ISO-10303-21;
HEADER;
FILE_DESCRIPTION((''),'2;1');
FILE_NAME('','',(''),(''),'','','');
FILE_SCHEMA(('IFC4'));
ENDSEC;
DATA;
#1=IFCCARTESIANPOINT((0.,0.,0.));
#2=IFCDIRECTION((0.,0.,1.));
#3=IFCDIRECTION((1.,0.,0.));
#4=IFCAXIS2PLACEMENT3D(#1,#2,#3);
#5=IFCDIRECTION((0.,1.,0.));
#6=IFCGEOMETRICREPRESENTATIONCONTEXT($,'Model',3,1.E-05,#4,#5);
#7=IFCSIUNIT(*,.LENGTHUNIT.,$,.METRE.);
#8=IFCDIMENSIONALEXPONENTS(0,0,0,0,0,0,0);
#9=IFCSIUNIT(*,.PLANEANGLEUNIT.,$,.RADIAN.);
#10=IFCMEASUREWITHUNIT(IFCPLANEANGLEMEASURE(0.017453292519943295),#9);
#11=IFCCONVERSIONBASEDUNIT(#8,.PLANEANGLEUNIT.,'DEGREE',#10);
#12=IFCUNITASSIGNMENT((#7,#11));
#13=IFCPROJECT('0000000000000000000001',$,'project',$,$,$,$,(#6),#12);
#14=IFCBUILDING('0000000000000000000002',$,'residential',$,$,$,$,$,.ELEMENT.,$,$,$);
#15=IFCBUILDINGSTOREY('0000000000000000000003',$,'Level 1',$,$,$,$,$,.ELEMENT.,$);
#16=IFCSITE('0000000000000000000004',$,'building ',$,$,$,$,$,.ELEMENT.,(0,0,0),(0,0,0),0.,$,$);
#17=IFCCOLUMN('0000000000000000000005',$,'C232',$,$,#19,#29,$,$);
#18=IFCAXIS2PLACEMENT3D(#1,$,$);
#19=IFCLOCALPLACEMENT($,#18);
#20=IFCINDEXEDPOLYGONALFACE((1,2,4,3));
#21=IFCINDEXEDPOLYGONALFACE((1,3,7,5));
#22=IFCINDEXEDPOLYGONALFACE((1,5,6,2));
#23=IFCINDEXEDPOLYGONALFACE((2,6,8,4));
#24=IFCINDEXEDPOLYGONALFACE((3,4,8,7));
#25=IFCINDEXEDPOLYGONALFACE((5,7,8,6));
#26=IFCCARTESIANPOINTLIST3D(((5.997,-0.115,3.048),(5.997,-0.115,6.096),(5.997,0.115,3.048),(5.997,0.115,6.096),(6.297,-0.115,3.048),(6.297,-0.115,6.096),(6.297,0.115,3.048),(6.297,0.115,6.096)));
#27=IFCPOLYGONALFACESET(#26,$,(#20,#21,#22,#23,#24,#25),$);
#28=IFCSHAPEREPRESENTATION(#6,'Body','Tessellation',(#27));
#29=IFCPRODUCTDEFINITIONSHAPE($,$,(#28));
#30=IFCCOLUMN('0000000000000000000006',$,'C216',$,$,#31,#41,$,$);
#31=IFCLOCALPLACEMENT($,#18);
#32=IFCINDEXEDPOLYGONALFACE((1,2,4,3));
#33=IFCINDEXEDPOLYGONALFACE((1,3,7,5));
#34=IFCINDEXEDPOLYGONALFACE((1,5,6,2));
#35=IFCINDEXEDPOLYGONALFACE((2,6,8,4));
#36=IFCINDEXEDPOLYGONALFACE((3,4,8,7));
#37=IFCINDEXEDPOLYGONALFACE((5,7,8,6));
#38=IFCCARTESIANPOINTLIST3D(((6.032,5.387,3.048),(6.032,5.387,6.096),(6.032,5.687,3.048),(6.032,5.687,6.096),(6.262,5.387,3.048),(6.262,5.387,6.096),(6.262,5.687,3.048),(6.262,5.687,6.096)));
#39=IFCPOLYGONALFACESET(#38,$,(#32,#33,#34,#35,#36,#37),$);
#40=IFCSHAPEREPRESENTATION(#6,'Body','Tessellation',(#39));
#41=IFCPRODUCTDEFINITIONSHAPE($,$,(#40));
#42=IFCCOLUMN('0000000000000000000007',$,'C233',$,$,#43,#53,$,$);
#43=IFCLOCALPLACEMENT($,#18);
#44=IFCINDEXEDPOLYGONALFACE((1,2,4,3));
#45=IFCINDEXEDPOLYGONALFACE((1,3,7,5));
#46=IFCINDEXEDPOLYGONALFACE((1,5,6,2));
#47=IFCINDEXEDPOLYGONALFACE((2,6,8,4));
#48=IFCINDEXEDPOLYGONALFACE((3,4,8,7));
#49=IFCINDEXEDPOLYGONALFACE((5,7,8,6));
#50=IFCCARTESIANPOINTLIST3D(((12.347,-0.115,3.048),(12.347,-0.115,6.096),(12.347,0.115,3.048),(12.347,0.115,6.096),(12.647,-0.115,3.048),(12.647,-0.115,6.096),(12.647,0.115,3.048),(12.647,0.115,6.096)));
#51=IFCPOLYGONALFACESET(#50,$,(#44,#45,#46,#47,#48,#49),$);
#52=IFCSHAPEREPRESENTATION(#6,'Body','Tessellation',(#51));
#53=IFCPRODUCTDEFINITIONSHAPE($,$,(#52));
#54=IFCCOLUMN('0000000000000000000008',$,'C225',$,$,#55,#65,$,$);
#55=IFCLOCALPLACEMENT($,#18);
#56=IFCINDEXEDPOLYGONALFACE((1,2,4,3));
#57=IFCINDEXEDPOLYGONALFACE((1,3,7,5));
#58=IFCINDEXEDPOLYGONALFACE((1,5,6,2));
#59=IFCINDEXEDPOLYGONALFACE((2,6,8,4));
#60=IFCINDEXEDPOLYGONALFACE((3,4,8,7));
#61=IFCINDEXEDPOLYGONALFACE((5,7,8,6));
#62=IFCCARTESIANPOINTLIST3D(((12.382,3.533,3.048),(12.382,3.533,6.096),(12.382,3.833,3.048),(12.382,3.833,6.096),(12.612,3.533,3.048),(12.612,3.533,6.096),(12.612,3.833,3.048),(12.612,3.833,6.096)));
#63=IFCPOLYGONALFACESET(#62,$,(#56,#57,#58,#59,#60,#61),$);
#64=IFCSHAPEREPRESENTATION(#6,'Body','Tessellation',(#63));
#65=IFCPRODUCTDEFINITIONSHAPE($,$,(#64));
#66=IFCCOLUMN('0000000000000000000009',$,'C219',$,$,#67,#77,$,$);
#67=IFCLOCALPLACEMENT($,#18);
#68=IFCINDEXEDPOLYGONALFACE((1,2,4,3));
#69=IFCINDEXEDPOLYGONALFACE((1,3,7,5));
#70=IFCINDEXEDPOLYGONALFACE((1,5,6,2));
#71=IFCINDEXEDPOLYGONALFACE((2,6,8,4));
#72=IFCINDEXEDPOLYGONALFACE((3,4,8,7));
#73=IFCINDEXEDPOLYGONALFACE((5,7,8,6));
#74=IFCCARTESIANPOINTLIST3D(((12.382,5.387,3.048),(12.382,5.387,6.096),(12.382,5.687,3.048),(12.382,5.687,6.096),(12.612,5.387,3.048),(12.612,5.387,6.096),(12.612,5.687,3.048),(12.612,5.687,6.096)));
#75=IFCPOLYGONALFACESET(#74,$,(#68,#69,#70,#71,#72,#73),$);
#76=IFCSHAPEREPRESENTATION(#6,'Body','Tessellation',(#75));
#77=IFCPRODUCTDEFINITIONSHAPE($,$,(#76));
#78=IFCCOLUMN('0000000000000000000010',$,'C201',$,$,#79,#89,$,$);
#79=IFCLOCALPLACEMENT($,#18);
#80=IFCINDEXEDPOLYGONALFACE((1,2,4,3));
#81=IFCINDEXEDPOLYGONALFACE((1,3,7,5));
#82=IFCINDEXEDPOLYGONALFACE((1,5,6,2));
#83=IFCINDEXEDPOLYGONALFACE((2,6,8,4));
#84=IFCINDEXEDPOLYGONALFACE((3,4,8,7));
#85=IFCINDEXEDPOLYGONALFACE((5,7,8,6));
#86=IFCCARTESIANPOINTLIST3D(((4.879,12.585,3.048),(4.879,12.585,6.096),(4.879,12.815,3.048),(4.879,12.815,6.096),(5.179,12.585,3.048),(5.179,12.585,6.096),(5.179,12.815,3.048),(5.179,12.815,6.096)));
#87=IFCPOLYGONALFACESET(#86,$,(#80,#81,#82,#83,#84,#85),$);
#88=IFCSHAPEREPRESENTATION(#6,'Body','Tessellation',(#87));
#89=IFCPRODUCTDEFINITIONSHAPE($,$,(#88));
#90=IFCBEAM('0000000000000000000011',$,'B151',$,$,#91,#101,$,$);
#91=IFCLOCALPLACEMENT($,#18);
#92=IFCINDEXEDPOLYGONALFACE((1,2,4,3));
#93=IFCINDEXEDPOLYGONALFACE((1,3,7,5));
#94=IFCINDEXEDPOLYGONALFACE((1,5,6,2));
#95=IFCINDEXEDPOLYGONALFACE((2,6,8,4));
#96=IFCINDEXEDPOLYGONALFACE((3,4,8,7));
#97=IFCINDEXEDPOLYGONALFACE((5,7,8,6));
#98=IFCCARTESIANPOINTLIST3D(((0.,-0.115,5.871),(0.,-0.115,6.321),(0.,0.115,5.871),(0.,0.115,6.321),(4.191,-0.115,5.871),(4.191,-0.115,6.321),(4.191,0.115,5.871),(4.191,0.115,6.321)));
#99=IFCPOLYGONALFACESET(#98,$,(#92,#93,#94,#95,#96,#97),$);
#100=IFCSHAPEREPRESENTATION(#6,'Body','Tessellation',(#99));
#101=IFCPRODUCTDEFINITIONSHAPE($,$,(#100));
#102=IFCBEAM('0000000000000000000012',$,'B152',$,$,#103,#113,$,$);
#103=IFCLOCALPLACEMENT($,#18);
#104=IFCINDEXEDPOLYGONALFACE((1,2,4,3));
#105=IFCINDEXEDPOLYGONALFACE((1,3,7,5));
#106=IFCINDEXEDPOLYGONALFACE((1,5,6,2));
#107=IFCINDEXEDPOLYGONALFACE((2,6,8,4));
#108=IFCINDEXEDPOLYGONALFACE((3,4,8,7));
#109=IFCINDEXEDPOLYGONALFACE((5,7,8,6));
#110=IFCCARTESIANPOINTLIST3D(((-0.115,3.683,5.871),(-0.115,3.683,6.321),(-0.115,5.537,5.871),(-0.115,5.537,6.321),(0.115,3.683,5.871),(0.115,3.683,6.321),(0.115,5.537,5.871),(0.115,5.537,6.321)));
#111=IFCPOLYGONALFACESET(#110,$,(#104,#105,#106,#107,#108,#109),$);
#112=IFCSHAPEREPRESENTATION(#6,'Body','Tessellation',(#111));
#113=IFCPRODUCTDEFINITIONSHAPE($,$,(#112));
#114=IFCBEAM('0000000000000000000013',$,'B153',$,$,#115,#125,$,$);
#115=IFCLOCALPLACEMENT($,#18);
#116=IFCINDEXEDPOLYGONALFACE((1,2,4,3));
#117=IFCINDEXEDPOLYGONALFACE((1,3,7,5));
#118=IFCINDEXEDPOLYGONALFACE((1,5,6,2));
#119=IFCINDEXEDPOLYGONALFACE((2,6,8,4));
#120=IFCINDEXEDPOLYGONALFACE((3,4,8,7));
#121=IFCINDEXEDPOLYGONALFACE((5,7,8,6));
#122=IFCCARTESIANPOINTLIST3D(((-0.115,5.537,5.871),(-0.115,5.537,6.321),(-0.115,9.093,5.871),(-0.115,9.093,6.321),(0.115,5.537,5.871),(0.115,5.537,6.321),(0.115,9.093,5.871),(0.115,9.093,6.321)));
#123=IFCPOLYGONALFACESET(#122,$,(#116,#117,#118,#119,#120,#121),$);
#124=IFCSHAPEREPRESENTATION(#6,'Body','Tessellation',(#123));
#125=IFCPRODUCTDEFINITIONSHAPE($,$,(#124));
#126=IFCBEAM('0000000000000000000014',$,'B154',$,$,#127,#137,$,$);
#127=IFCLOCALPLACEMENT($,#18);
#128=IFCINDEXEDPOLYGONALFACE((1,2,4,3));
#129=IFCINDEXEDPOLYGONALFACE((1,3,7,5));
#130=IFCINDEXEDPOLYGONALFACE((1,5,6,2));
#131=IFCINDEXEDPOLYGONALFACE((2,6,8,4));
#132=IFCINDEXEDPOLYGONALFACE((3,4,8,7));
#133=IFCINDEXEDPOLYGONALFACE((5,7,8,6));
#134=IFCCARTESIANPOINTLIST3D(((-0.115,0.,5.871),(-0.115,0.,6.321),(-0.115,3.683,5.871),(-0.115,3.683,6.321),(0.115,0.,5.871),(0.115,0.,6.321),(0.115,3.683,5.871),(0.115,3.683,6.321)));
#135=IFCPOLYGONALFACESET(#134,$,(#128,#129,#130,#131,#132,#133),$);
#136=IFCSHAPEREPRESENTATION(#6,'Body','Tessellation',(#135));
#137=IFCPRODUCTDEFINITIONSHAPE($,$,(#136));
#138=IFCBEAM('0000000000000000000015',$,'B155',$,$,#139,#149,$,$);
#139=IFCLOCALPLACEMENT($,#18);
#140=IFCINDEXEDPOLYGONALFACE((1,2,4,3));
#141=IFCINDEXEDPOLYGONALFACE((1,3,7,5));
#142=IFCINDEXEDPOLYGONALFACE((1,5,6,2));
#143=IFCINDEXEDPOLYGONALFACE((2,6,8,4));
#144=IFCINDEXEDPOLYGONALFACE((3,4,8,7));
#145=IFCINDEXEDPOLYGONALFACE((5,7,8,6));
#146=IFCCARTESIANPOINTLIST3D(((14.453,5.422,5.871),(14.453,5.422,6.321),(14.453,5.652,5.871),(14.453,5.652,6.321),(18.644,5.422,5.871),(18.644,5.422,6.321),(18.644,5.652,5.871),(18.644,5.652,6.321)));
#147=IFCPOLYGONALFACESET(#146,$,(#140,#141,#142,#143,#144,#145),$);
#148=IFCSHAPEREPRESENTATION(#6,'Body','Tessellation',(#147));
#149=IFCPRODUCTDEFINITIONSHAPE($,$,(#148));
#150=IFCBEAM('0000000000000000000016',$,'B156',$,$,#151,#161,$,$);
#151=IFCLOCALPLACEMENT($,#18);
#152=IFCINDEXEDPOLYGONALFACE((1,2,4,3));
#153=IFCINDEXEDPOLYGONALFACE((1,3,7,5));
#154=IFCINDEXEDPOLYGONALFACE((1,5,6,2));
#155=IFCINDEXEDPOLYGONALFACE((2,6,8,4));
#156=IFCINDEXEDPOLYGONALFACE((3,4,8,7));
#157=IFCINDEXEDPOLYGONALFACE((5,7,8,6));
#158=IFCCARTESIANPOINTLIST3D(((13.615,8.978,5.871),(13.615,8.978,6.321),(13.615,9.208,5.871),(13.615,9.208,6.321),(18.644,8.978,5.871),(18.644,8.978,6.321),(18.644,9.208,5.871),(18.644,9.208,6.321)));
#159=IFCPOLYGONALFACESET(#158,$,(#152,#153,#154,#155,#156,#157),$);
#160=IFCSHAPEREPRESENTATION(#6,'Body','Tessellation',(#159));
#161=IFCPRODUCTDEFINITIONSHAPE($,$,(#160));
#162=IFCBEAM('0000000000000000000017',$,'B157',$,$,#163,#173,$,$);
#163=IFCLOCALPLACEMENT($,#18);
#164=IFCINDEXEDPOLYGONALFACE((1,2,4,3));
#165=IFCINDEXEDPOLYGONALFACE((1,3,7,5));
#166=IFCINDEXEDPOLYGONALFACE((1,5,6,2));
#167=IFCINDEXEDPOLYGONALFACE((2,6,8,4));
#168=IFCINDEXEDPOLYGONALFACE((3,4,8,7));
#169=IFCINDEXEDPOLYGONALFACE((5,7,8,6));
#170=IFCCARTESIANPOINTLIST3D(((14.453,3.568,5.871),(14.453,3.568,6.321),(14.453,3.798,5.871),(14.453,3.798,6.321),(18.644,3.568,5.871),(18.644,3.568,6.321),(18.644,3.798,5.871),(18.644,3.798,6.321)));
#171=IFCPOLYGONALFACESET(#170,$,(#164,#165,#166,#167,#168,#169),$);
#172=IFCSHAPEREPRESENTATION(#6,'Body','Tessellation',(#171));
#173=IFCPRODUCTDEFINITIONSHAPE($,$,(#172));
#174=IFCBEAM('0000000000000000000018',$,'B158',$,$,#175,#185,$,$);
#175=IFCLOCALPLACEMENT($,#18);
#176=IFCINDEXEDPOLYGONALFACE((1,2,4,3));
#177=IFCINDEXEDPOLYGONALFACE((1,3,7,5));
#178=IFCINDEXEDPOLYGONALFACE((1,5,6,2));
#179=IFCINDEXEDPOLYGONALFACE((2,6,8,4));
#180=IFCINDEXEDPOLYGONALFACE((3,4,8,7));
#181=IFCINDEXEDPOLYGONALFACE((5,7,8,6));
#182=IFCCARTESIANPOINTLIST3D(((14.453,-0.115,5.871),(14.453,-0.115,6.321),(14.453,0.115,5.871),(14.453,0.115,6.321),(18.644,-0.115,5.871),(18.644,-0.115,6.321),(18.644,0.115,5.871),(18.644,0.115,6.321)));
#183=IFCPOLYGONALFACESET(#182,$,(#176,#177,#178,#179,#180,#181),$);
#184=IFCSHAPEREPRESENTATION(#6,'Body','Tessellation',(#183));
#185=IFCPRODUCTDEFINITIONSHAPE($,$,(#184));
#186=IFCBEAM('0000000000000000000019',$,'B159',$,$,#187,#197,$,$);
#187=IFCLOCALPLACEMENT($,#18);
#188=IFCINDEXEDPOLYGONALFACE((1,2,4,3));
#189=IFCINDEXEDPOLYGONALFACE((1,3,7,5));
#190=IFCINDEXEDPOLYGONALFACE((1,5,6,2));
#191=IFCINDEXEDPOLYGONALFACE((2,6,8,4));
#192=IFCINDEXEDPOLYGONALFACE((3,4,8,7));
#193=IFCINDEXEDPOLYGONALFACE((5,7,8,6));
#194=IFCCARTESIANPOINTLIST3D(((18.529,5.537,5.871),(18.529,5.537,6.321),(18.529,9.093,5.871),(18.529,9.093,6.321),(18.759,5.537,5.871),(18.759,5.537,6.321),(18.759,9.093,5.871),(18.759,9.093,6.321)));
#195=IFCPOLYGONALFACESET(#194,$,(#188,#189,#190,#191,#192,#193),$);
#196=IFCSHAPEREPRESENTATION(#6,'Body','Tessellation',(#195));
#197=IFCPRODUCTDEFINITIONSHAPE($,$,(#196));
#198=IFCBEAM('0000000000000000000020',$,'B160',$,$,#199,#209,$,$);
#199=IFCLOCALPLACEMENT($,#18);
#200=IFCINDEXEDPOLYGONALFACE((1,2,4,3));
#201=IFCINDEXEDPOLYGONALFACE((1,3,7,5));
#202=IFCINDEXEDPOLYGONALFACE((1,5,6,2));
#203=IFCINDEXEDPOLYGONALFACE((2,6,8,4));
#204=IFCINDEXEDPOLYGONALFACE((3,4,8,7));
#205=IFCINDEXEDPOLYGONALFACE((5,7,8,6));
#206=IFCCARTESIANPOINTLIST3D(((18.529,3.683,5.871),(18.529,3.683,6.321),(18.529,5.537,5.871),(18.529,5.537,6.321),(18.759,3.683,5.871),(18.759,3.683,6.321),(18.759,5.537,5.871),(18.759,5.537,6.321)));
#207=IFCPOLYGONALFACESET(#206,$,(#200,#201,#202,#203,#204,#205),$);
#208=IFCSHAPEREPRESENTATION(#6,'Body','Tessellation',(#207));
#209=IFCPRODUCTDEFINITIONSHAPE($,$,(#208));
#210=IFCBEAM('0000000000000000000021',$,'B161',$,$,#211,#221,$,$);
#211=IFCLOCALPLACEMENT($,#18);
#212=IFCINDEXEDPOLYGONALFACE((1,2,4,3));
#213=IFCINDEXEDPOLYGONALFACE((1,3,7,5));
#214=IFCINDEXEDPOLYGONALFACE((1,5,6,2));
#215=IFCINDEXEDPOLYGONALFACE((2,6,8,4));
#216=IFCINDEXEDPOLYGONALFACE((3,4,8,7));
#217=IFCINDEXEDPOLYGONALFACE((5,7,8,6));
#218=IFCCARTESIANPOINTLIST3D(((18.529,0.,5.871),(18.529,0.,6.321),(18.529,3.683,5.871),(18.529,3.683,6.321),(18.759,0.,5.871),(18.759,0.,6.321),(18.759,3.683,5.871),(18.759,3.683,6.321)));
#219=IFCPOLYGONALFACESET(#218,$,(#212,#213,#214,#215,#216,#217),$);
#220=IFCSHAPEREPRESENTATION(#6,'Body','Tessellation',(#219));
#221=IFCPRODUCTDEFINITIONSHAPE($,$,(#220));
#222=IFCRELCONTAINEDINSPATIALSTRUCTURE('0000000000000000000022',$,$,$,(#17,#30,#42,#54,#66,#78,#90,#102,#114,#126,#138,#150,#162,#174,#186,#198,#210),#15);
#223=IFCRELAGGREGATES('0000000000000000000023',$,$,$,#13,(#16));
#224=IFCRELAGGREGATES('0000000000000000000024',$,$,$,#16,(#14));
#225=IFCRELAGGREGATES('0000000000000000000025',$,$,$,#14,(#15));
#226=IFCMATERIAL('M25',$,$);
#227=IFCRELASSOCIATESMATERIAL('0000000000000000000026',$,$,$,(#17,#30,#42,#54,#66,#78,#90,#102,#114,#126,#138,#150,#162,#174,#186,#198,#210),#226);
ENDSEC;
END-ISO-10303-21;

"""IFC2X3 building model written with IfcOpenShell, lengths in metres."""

from ifc_helpers import new_model, entity, si_unit, converted_unit, direction, frame, frame_2d, origin_with_axes, place, context, project, spatial, rectangle, extrude, material, element, save


model = new_model("IFC2X3")

# Units and contexts
model_context = context("Model", 3, precision=1e-05, world=origin_with_axes(), true_north=direction((0.0, 1.0, 0.0)))
ifc_project = project(units=[si_unit("LENGTHUNIT", "METRE"), converted_unit("PLANEANGLEUNIT", "DEGREE", entity("IfcPlaneAngleMeasure", 0.017453292519943295), si_unit("PLANEANGLEUNIT", "RADIAN"), dimensions=[0, 0, 0, 0, 0, 0, 0])], contexts=[model_context])

# Site, building, storey
site = spatial("IfcSite", under=ifc_project, Name="building ", CompositionType="ELEMENT", RefLatitude=(0, 0, 0), RefLongitude=(0, 0, 0), RefElevation=0.0)
building = spatial("IfcBuilding", under=site, Name="residential", CompositionType="ELEMENT")
storey = spatial("IfcBuildingStorey", under=building, Name="Level 1", CompositionType="ELEMENT")

# Columns
ifc_material = material(Name="M25")
placement = place(None, origin_with_axes())
element("IfcColumn", 1, at=placement, inside=storey, material=ifc_material, Name="C232", context=model_context, shape_type="SweptSolid", body=[
    extrude(rectangle(XDim=0.3, YDim=0.23, at=frame_2d((0.0, 0.0), x_axis=(1.0, 0.0, 0.0))), frame((6.147, 0.0, 3.048), z_axis=(0.0, 0.0, 1.0), x_axis=(1.0, 0.0, 0.0)), (0.0, 0.0, 1.0), 3.048),
])
element("IfcColumn", 2, at=placement, inside=storey, material=ifc_material, Name="C216", context=model_context, shape_type="SweptSolid", body=[
    extrude(rectangle(XDim=0.23, YDim=0.3, at=frame_2d((0.0, 0.0), x_axis=(1.0, 0.0, 0.0))), frame((6.147, 5.537, 3.048), z_axis=(0.0, 0.0, 1.0), x_axis=(1.0, 0.0, 0.0)), (0.0, 0.0, 1.0), 3.048),
])
element("IfcColumn", 3, at=placement, inside=storey, material=ifc_material, Name="C233", context=model_context, shape_type="SweptSolid", body=[
    extrude(rectangle(XDim=0.3, YDim=0.23, at=frame_2d((0.0, 0.0), x_axis=(1.0, 0.0, 0.0))), frame((12.497, 0.0, 3.048), z_axis=(0.0, 0.0, 1.0), x_axis=(1.0, 0.0, 0.0)), (0.0, 0.0, 1.0), 3.048),
])
element("IfcColumn", 4, at=placement, inside=storey, material=ifc_material, Name="C225", context=model_context, shape_type="SweptSolid", body=[
    extrude(rectangle(XDim=0.23, YDim=0.3, at=frame_2d((0.0, 0.0), x_axis=(1.0, 0.0, 0.0))), frame((12.497, 3.683, 3.048), z_axis=(0.0, 0.0, 1.0), x_axis=(1.0, 0.0, 0.0)), (0.0, 0.0, 1.0), 3.048),
])
element("IfcColumn", 5, at=placement, inside=storey, material=ifc_material, Name="C219", context=model_context, shape_type="SweptSolid", body=[
    extrude(rectangle(XDim=0.23, YDim=0.3, at=frame_2d((0.0, 0.0), x_axis=(1.0, 0.0, 0.0))), frame((12.497, 5.537, 3.048), z_axis=(0.0, 0.0, 1.0), x_axis=(1.0, 0.0, 0.0)), (0.0, 0.0, 1.0), 3.048),
])
element("IfcColumn", 6, at=placement, inside=storey, material=ifc_material, Name="C201", context=model_context, shape_type="SweptSolid", body=[
    extrude(rectangle(XDim=0.3, YDim=0.23, at=frame_2d((0.0, 0.0), x_axis=(1.0, 0.0, 0.0))), frame((5.029, 12.7, 3.048), z_axis=(0.0, 0.0, 1.0), x_axis=(1.0, 0.0, 0.0)), (0.0, 0.0, 1.0), 3.048),
])

# Beams
element("IfcBeam", 7, at=placement, inside=storey, material=ifc_material, Name="B151", context=model_context, shape_type="SweptSolid", body=[
    extrude(rectangle(XDim=0.23, YDim=0.45, at=frame_2d((0.0, 0.0), x_axis=(0.0, 1.0, 0.0))), frame((0.0, 0.0, 6.096), z_axis=(1.0, 0.0, 0.0), x_axis=(0.0, 0.0, -1.0)), (0.0, 0.0, 1.0), 4.191),
])
element("IfcBeam", 8, at=placement, inside=storey, material=ifc_material, Name="B152", context=model_context, shape_type="SweptSolid", body=[
    extrude(rectangle(XDim=0.23, YDim=0.45, at=frame_2d((0.0, 0.0), x_axis=(0.0, 1.0, 0.0))), frame((0.0, 3.683, 6.096), z_axis=(0.0, 1.0, 0.0), x_axis=(0.0, 0.0, -1.0)), (0.0, 0.0, 1.0), 1.854),
])
element("IfcBeam", 9, at=placement, inside=storey, material=ifc_material, Name="B153", context=model_context, shape_type="SweptSolid", body=[
    extrude(rectangle(XDim=0.23, YDim=0.45, at=frame_2d((0.0, 0.0), x_axis=(0.0, 1.0, 0.0))), frame((0.0, 5.537, 6.096), z_axis=(0.0, 1.0, 0.0), x_axis=(0.0, 0.0, -1.0)), (0.0, 0.0, 1.0), 3.556),
])
element("IfcBeam", 10, at=placement, inside=storey, material=ifc_material, Name="B154", context=model_context, shape_type="SweptSolid", body=[
    extrude(rectangle(XDim=0.23, YDim=0.45, at=frame_2d((0.0, 0.0), x_axis=(0.0, 1.0, 0.0))), frame((0.0, 0.0, 6.096), z_axis=(0.0, 1.0, 0.0), x_axis=(0.0, 0.0, -1.0)), (0.0, 0.0, 1.0), 3.683),
])
element("IfcBeam", 11, at=placement, inside=storey, material=ifc_material, Name="B155", context=model_context, shape_type="SweptSolid", body=[
    extrude(rectangle(XDim=0.23, YDim=0.45, at=frame_2d((0.0, 0.0), x_axis=(0.0, 1.0, 0.0))), frame((18.644, 5.537, 6.096), z_axis=(-1.0, 0.0, 0.0), x_axis=(0.0, 0.0, -1.0)), (0.0, 0.0, 1.0), 4.191),
])
element("IfcBeam", 12, at=placement, inside=storey, material=ifc_material, Name="B156", context=model_context, shape_type="SweptSolid", body=[
    extrude(rectangle(XDim=0.23, YDim=0.45, at=frame_2d((0.0, 0.0), x_axis=(0.0, 1.0, 0.0))), frame((18.644, 9.093, 6.096), z_axis=(-1.0, 0.0, 0.0), x_axis=(0.0, 0.0, -1.0)), (0.0, 0.0, 1.0), 5.029),
])
element("IfcBeam", 13, at=placement, inside=storey, material=ifc_material, Name="B157", context=model_context, shape_type="SweptSolid", body=[
    extrude(rectangle(XDim=0.23, YDim=0.45, at=frame_2d((0.0, 0.0), x_axis=(0.0, 1.0, 0.0))), frame((18.644, 3.683, 6.096), z_axis=(-1.0, 0.0, 0.0), x_axis=(0.0, 0.0, -1.0)), (0.0, 0.0, 1.0), 4.191),
])
element("IfcBeam", 14, at=placement, inside=storey, material=ifc_material, Name="B158", context=model_context, shape_type="SweptSolid", body=[
    extrude(rectangle(XDim=0.23, YDim=0.45, at=frame_2d((0.0, 0.0), x_axis=(0.0, 1.0, 0.0))), frame((18.644, 0.0, 6.096), z_axis=(-1.0, 0.0, 0.0), x_axis=(0.0, 0.0, -1.0)), (0.0, 0.0, 1.0), 4.191),
])
element("IfcBeam", 15, at=placement, inside=storey, material=ifc_material, Name="B159", context=model_context, shape_type="SweptSolid", body=[
    extrude(rectangle(XDim=0.23, YDim=0.45, at=frame_2d((0.0, 0.0), x_axis=(0.0, 1.0, 0.0))), frame((18.644, 9.093, 6.096), z_axis=(0.0, -1.0, 0.0), x_axis=(0.0, 0.0, -1.0)), (0.0, 0.0, 1.0), 3.556),
])
element("IfcBeam", 16, at=placement, inside=storey, material=ifc_material, Name="B160", context=model_context, shape_type="SweptSolid", body=[
    extrude(rectangle(XDim=0.23, YDim=0.45, at=frame_2d((0.0, 0.0), x_axis=(0.0, 1.0, 0.0))), frame((18.644, 3.683, 6.096), z_axis=(0.0, 1.0, 0.0), x_axis=(0.0, 0.0, -1.0)), (0.0, 0.0, 1.0), 1.854),
])
element("IfcBeam", 17, at=placement, inside=storey, material=ifc_material, Name="B161", context=model_context, shape_type="SweptSolid", body=[
    extrude(rectangle(XDim=0.23, YDim=0.45, at=frame_2d((0.0, 0.0), x_axis=(0.0, 1.0, 0.0))), frame((18.644, 0.0, 6.096), z_axis=(0.0, 1.0, 0.0), x_axis=(0.0, 0.0, -1.0)), (0.0, 0.0, 1.0), 3.683),
])

save(model, "model.ifc")
